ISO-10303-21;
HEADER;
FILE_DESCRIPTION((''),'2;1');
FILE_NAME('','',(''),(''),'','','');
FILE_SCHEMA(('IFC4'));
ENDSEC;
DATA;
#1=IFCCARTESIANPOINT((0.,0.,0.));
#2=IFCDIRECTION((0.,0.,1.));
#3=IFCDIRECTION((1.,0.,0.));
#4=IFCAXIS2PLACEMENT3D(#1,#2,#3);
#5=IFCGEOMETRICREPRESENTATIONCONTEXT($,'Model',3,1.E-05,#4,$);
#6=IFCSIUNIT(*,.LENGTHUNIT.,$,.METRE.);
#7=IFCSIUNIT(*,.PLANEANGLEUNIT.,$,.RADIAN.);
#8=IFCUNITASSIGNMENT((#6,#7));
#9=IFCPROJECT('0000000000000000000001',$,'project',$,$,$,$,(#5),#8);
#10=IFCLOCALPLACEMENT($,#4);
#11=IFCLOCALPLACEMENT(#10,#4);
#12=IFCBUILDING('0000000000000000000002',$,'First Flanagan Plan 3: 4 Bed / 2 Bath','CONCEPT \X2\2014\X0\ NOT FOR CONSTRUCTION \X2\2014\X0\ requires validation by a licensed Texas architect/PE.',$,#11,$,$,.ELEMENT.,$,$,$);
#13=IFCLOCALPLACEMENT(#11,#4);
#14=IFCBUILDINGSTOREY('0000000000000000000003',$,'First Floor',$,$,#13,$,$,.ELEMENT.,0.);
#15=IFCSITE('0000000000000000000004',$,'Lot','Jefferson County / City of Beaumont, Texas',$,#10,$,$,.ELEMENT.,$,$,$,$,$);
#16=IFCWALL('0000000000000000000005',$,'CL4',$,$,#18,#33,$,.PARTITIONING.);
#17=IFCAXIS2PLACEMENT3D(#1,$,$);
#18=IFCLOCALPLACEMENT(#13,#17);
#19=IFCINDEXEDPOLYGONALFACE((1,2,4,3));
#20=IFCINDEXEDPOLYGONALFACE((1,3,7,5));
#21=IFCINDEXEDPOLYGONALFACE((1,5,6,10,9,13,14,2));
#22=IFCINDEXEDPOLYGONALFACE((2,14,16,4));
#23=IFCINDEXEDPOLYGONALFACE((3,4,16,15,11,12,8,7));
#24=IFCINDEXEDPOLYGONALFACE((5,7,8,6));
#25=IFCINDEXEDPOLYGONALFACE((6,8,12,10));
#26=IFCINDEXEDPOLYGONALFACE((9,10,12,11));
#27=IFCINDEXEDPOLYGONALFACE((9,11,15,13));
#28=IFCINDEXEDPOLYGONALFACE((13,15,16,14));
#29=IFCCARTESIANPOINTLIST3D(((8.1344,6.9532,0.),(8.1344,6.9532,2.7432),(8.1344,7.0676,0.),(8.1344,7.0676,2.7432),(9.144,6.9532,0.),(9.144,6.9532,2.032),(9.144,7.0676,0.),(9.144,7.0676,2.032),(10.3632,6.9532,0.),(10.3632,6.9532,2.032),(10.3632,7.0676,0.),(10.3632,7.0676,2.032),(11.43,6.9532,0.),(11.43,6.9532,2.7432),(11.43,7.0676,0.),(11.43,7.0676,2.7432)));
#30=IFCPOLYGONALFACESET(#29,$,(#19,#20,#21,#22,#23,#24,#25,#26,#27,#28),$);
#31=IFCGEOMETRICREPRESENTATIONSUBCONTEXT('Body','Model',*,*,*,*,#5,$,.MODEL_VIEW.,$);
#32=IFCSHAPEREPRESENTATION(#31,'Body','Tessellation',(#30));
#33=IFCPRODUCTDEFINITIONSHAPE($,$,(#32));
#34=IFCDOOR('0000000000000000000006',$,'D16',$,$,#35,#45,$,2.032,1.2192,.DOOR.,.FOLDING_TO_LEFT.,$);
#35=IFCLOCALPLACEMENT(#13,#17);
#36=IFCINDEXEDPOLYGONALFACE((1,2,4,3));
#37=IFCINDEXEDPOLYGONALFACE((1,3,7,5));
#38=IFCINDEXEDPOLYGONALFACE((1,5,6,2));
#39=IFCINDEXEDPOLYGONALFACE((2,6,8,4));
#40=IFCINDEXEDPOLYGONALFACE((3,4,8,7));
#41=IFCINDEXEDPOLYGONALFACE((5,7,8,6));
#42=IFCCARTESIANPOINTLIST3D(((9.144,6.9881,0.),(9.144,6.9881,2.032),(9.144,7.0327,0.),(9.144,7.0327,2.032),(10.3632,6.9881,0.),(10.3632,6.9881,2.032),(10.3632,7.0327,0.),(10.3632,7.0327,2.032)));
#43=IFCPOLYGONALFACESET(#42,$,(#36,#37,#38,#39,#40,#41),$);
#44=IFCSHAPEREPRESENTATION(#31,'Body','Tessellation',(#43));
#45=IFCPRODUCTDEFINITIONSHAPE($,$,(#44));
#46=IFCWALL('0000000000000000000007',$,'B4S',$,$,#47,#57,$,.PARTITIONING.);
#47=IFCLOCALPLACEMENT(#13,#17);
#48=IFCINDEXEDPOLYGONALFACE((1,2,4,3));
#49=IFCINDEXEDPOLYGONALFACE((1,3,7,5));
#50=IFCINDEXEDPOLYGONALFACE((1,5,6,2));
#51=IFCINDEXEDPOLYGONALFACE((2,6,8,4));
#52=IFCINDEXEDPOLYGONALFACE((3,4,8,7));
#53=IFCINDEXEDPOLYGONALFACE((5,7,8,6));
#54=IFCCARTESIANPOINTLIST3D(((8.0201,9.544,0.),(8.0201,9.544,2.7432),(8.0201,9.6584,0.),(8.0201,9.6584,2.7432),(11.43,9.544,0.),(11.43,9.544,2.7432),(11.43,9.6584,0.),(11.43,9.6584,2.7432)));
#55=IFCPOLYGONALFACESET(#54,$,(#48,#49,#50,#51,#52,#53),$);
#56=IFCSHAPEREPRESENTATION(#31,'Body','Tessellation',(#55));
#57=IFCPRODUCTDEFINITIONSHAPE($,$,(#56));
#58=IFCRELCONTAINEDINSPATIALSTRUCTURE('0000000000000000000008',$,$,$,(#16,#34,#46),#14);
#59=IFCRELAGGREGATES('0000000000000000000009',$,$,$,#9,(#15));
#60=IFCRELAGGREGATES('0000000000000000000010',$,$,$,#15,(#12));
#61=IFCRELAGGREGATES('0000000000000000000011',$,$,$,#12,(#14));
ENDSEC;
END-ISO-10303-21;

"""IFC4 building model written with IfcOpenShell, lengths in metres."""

from ifc_helpers import new_model, si_unit, frame, frame_2d, origin_with_axes, place, context, subcontext, project, spatial, rectangle, extrude, element, fill, save


model = new_model("IFC4")

# Units and contexts
model_context = context("Model", 3, precision=1e-05, world=origin_with_axes())
body_context = subcontext(model_context, "Body", "Model", "MODEL_VIEW")
ifc_project = project(units=[si_unit("LENGTHUNIT", "METRE"), si_unit("PLANEANGLEUNIT", "RADIAN")], contexts=[model_context])

# Site, building, storey
site_placement = place(None, origin_with_axes())
site = spatial("IfcSite", under=ifc_project, at=site_placement, Name="Lot", Description="Jefferson County / City of Beaumont, Texas", CompositionType="ELEMENT")
building_placement = place(site_placement, origin_with_axes())
building = spatial("IfcBuilding", under=site, at=building_placement, Name="First Flanagan Plan 3: 4 Bed / 2 Bath", Description="CONCEPT — NOT FOR CONSTRUCTION — requires validation by a licensed Texas architect/PE.", CompositionType="ELEMENT")
storey_placement = place(building_placement, origin_with_axes())
storey = spatial("IfcBuildingStorey", under=building, at=storey_placement, Name="First Floor", CompositionType="ELEMENT", Elevation=0.0)

# Wall, opening, door
wall_1_placement = place(storey_placement, frame((8.1343, 7.0104, 0.0), z_axis=(0.0, 0.0, 1.0), x_axis=(1.0, 0.0, 0.0)))
wall_1 = element("IfcWall", 1, at=wall_1_placement, inside=storey, Name="CL4", PredefinedType="PARTITIONING", context=body_context, shape_type="SweptSolid", body=[
    extrude(rectangle(XDim=3.2957, YDim=0.1143, at=frame_2d((1.6478, 0.0), x_axis=(1.0, 0.0))), origin_with_axes(), (0.0, 0.0, 1.0), 2.7432),
])
opening_1_placement = place(wall_1_placement, frame((1.0097, 0.0, 0.0), z_axis=(0.0, 0.0, 1.0), x_axis=(1.0, 0.0, 0.0)))
opening_1 = element("IfcOpeningElement", 2, at=opening_1_placement, cuts=wall_1, PredefinedType="OPENING", context=body_context, shape_type="SweptSolid", body=[
    extrude(rectangle(XDim=1.2192, YDim=0.1448, at=frame_2d((0.6096, 0.0), x_axis=(1.0, 0.0))), origin_with_axes(), (0.0, 0.0, 1.0), 2.032),
])
door_1_placement = place(opening_1_placement, origin_with_axes())
door_1 = element("IfcDoor", 3, at=door_1_placement, inside=storey, Name="D16", OperationType="FOLDING_TO_LEFT", OverallHeight=2.032, OverallWidth=1.2192, PredefinedType="DOOR", context=body_context, shape_type="SweptSolid", body=[
    extrude(rectangle(XDim=1.2192, YDim=0.0445, at=frame_2d((0.6096, 0.0), x_axis=(1.0, 0.0))), origin_with_axes(), (0.0, 0.0, 1.0), 2.032),
])
fill(opening_1, door_1)

# Wall
wall_2_placement = place(storey_placement, frame((8.0201, 9.6012, 0.0), z_axis=(0.0, 0.0, 1.0), x_axis=(1.0, 0.0, 0.0)))
element("IfcWall", 4, at=wall_2_placement, inside=storey, Name="B4S", PredefinedType="PARTITIONING", context=body_context, shape_type="SweptSolid", body=[
    extrude(rectangle(XDim=3.41, YDim=0.1143, at=frame_2d((1.705, 0.0), x_axis=(1.0, 0.0))), origin_with_axes(), (0.0, 0.0, 1.0), 2.7432),
])

save(model, "model.ifc")
